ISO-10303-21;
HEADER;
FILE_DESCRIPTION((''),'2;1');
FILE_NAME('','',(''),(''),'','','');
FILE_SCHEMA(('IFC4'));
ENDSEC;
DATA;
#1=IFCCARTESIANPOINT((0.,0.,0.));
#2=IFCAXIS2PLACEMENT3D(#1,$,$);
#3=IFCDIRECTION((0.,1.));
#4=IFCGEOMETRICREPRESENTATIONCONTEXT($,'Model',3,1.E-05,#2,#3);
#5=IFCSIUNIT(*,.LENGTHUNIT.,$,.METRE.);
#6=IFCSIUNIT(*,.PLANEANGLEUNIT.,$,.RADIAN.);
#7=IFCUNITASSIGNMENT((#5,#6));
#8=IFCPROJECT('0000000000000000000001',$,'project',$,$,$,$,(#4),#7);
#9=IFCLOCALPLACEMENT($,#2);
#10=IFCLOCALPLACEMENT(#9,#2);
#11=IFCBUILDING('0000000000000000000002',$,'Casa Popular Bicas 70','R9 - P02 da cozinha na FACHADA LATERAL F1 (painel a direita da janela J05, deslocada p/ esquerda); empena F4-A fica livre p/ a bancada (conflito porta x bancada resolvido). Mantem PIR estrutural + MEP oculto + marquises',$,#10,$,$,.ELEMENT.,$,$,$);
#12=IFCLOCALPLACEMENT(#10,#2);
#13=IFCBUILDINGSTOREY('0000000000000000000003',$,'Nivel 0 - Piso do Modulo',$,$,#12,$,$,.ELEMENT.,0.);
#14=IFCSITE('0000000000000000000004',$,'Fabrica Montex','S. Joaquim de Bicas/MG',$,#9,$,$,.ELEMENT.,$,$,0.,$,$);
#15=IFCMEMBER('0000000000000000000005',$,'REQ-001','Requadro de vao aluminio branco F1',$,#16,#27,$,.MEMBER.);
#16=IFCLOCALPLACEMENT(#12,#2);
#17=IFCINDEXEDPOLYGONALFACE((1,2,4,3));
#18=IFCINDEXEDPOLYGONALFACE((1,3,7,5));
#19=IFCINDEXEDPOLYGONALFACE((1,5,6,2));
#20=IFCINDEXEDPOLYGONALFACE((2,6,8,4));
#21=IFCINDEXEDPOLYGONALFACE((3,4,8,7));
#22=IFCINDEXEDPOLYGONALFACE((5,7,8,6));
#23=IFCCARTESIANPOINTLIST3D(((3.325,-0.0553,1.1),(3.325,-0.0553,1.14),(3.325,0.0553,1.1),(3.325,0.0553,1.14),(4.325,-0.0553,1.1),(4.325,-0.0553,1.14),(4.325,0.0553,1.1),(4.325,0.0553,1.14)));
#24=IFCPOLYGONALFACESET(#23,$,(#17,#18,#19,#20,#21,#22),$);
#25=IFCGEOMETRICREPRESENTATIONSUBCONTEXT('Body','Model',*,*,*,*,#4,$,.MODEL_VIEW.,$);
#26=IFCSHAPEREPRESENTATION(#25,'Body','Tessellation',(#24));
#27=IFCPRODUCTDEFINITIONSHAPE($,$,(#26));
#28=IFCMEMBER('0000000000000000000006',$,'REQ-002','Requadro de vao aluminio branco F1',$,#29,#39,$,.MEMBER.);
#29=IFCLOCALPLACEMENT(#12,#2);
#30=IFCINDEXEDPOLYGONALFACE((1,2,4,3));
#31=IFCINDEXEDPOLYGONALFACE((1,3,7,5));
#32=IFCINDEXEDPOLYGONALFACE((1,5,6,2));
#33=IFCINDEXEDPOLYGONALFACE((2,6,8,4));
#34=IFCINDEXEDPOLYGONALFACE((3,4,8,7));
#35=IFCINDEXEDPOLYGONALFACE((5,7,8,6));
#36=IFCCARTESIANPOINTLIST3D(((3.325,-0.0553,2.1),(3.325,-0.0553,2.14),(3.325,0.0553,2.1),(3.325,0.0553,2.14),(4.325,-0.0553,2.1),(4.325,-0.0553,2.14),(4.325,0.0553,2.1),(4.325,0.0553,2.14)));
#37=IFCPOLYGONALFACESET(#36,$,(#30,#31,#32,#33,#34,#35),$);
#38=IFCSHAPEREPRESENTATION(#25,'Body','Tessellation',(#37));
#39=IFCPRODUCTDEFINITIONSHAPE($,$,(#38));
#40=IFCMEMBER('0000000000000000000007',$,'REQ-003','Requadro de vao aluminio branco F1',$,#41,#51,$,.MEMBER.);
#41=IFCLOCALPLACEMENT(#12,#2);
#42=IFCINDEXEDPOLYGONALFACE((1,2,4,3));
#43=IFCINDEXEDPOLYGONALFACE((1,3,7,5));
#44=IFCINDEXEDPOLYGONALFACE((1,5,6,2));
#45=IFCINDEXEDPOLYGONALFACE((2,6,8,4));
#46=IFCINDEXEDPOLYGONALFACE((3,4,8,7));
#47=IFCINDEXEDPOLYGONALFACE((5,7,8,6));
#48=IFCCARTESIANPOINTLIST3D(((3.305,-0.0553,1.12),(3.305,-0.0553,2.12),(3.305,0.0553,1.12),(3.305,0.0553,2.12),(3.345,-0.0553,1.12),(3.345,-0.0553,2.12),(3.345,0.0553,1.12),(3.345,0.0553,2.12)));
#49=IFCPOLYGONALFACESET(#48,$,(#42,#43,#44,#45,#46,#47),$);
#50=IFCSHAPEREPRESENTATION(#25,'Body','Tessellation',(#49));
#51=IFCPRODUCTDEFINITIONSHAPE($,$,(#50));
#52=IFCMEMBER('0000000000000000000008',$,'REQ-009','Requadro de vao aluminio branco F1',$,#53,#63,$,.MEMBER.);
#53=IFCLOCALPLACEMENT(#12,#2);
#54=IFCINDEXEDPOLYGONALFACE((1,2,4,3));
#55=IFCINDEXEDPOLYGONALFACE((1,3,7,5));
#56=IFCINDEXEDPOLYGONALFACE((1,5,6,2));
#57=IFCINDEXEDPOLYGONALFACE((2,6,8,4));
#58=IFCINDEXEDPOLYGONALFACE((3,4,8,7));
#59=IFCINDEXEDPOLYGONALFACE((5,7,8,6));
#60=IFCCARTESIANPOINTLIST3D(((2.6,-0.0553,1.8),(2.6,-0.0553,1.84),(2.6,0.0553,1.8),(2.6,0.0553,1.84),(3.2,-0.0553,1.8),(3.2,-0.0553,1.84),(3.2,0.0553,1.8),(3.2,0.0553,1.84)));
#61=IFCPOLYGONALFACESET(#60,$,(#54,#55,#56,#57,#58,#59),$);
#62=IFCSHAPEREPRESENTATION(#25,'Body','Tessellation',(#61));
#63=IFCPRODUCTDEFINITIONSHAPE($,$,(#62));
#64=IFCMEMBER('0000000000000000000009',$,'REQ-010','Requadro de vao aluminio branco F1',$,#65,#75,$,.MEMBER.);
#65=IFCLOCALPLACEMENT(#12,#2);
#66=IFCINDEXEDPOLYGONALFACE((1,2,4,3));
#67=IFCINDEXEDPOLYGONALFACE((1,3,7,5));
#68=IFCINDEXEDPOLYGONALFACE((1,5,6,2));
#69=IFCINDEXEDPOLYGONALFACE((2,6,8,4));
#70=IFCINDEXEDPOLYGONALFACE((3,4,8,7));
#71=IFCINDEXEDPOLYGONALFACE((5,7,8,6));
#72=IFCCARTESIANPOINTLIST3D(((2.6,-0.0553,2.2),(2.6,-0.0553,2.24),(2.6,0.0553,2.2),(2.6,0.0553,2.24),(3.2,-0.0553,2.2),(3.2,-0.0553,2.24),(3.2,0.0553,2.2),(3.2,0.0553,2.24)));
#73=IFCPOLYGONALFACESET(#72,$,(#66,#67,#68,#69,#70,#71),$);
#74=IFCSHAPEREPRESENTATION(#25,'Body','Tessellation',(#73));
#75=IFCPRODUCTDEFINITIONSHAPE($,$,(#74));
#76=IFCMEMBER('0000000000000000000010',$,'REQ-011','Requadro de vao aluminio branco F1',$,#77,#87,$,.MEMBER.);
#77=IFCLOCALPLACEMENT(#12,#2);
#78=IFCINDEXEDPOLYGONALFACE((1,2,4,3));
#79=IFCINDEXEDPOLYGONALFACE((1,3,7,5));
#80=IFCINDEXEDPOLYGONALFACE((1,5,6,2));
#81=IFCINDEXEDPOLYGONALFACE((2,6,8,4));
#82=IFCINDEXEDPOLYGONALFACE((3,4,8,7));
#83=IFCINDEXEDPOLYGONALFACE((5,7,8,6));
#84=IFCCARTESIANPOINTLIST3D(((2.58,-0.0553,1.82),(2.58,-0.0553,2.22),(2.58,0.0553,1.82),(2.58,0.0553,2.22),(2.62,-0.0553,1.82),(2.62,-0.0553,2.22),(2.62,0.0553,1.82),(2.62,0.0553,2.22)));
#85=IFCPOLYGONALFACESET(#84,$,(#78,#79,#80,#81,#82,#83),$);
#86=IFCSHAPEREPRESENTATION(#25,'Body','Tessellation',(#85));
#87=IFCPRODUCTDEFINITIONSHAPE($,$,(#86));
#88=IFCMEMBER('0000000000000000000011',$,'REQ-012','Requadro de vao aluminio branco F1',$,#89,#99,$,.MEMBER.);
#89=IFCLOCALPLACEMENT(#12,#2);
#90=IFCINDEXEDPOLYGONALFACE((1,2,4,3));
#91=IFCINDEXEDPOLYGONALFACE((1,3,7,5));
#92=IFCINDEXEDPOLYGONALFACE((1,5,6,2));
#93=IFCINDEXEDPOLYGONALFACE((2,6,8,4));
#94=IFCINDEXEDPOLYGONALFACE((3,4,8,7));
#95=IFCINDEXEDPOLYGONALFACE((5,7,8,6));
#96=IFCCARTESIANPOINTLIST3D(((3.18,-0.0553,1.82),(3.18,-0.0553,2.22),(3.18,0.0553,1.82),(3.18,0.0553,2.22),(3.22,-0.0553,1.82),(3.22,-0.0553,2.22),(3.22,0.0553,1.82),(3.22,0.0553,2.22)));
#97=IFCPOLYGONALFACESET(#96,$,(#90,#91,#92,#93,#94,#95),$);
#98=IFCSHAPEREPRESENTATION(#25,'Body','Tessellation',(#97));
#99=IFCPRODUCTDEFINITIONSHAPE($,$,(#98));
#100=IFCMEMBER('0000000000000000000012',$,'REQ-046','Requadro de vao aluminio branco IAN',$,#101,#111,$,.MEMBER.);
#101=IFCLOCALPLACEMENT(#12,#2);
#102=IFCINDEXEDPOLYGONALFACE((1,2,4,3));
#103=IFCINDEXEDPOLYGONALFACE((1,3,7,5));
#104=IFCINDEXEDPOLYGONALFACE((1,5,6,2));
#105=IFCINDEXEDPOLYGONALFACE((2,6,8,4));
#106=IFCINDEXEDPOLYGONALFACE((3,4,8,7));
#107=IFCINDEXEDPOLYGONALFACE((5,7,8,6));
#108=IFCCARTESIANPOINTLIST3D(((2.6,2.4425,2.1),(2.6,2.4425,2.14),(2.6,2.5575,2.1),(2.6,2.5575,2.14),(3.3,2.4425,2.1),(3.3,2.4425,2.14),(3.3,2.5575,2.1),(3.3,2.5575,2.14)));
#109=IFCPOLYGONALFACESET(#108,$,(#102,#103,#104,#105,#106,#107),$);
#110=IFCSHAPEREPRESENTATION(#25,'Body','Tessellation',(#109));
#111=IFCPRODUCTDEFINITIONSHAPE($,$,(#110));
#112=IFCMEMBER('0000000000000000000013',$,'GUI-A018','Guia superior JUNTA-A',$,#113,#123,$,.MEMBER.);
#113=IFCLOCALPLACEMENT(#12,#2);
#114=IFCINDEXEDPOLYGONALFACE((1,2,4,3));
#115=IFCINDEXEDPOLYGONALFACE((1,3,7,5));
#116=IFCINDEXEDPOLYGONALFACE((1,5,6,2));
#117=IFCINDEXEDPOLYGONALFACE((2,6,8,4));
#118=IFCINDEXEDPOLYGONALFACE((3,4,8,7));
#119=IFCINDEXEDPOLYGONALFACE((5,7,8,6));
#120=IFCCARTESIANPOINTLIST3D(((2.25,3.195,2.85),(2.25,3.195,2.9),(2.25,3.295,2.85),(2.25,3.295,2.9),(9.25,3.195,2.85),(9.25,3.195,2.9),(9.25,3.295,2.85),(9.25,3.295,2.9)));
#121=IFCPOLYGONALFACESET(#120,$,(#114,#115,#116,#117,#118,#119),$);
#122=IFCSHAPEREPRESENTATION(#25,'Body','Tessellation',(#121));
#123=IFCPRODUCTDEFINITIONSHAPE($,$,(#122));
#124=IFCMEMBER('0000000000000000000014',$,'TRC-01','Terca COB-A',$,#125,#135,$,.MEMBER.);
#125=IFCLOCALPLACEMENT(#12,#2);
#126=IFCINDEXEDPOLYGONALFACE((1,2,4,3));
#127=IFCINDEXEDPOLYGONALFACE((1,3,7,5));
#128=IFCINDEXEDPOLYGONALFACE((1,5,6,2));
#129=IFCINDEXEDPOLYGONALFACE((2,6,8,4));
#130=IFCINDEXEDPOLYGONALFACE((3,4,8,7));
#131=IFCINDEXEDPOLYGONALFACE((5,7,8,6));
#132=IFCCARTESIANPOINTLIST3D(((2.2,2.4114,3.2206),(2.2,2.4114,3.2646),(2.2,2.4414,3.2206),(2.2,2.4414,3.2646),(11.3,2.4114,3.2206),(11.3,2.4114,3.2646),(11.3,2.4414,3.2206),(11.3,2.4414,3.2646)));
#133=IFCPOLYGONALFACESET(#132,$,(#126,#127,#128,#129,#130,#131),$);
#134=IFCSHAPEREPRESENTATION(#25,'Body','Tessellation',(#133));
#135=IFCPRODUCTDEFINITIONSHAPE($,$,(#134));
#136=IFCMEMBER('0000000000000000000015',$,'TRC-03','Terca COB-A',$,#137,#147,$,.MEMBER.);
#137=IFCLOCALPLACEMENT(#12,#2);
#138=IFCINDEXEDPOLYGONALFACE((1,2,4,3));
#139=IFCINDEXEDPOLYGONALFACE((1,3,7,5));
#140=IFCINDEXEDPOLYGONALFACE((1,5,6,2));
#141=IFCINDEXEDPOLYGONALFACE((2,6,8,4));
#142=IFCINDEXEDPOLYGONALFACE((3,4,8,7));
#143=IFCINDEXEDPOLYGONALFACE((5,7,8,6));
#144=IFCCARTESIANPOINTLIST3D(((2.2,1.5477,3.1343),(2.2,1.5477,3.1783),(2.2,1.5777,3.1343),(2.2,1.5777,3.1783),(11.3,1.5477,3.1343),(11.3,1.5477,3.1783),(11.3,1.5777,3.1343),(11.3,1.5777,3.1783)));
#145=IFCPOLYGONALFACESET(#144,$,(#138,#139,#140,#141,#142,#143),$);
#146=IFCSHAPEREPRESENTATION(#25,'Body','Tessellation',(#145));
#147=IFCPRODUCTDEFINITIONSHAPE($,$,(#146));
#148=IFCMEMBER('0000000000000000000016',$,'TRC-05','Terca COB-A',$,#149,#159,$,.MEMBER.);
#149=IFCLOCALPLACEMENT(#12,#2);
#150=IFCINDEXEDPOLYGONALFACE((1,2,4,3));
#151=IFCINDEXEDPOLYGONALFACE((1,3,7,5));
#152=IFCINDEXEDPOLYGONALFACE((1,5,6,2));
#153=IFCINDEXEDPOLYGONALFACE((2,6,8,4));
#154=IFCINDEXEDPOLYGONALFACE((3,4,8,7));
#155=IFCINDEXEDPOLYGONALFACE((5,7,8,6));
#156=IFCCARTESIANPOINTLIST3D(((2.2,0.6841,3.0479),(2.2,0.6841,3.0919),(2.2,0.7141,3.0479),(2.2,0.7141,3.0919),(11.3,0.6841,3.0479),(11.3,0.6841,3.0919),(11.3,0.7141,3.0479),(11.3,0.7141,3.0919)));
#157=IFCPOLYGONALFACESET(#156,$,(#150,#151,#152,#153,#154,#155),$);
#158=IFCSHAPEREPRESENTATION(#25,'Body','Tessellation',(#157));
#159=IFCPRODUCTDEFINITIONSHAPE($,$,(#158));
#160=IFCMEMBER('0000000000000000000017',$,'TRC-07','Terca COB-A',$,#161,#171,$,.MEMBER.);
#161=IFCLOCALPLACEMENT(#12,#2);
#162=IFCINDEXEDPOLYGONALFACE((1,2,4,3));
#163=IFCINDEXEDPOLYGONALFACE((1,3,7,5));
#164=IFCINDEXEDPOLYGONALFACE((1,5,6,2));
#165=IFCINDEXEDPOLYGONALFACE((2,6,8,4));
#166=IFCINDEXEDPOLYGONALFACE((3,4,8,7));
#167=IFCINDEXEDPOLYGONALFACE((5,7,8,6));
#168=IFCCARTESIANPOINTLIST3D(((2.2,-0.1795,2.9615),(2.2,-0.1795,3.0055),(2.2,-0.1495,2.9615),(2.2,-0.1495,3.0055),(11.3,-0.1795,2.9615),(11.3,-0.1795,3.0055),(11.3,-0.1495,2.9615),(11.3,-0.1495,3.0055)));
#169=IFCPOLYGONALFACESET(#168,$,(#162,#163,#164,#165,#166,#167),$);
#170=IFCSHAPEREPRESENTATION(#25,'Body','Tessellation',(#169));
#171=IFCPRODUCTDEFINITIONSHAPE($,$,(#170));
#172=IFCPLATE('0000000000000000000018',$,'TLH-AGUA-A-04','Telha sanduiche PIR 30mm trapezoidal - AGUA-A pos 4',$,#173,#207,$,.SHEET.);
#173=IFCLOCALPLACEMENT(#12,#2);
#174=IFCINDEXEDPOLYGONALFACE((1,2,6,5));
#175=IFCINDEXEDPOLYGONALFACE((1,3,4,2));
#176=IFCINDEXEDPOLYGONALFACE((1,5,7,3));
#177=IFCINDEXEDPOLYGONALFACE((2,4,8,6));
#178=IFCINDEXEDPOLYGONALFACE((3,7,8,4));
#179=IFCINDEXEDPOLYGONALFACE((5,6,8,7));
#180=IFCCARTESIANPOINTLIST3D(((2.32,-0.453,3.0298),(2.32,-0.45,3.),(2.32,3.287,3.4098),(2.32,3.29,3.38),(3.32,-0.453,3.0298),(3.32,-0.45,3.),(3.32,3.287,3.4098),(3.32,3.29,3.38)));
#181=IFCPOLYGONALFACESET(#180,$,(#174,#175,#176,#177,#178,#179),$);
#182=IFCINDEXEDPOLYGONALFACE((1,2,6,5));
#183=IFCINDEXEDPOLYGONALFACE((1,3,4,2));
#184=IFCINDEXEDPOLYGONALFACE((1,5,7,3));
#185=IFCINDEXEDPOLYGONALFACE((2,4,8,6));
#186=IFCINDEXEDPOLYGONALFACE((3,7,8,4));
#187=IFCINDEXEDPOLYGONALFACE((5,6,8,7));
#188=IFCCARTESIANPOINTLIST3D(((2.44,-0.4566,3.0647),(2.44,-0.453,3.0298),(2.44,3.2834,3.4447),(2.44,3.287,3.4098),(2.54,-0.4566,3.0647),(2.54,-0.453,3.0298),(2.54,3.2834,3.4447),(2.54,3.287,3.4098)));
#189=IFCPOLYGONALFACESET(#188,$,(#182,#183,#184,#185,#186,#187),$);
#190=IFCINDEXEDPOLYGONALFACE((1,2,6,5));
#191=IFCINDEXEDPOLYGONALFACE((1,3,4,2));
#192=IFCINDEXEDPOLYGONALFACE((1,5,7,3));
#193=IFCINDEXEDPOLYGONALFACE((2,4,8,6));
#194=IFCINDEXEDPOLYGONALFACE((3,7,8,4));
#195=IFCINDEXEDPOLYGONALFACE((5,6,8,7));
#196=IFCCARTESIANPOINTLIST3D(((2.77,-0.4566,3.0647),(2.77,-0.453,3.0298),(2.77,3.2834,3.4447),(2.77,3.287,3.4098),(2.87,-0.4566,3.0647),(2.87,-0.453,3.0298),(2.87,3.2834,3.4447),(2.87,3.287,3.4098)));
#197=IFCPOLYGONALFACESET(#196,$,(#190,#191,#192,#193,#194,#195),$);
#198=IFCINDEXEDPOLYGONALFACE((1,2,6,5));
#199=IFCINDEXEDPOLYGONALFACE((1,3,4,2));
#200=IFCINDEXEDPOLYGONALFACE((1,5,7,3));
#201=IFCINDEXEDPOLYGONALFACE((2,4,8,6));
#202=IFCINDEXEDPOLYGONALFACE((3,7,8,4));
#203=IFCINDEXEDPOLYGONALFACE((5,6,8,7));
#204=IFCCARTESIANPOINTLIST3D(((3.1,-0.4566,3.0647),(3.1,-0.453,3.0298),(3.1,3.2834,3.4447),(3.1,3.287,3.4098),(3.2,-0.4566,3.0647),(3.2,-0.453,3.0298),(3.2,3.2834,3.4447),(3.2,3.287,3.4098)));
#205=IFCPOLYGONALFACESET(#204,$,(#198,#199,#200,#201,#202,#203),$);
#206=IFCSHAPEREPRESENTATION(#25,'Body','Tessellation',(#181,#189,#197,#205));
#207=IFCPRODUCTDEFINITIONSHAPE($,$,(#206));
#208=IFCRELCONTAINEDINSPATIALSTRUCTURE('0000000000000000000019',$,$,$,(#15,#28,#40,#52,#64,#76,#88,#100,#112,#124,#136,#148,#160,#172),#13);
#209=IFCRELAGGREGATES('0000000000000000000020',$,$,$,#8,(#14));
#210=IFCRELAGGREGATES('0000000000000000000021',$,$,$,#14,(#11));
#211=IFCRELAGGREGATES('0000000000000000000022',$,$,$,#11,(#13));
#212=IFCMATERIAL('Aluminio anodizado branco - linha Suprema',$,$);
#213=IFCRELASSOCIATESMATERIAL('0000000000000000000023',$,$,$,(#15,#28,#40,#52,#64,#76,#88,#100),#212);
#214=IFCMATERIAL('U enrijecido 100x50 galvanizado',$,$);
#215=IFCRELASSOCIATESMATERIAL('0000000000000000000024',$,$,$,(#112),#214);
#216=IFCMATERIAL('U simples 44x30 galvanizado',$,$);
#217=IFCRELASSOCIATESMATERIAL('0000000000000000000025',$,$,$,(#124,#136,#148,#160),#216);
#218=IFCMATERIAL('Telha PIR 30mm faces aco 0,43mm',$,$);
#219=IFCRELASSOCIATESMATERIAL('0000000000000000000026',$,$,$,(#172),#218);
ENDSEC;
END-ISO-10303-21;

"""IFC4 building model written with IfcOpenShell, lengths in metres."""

from ifc_helpers import new_model, si_unit, direction, frame, frame_2d, origin, origin_2d, place, context, subcontext, project, spatial, rectangle, extrude, material, element, save


model = new_model("IFC4")

# Units and contexts
model_context = context("Model", 3, precision=1e-05, world=origin(), true_north=direction((0.0, 1.0)))
body_context = subcontext(model_context, "Body", "Model", "MODEL_VIEW")
ifc_project = project(units=[si_unit("LENGTHUNIT", "METRE"), si_unit("PLANEANGLEUNIT", "RADIAN")], contexts=[model_context])

# Site, building, storey
site_placement = place(None, origin())
site = spatial("IfcSite", under=ifc_project, at=site_placement, Name="Fabrica Montex", Description="S. Joaquim de Bicas/MG", CompositionType="ELEMENT", RefElevation=0.0)
building_placement = place(site_placement, origin())
building = spatial("IfcBuilding", under=site, at=building_placement, Name="Casa Popular Bicas 70", Description="R9 - P02 da cozinha na FACHADA LATERAL F1 (painel a direita da janela J05, deslocada p/ esquerda); empena F4-A fica livre p/ a bancada (conflito porta x bancada resolvido). Mantem PIR estrutural + MEP oculto + marquises", CompositionType="ELEMENT")
storey_placement = place(building_placement, origin())
storey = spatial("IfcBuildingStorey", under=building, at=storey_placement, Name="Nivel 0 - Piso do Modulo", CompositionType="ELEMENT", Elevation=0.0)

# Members
ifc_material_1 = material(Name="Aluminio anodizado branco - linha Suprema")
for number, where, z_axis, x_axis, name in (
    (1, (3.325, 0.0, 1.12), (1.0, 0.0, 0.0), (0.0, 0.0, 1.0), "REQ-001"),
    (2, (3.325, 0.0, 2.12), (1.0, 0.0, 0.0), (0.0, 0.0, 1.0), "REQ-002"),
    (3, (3.325, 0.0, 1.12), (0.0, 0.0, 1.0), (1.0, 0.0, 0.0), "REQ-003"),
):
    element("IfcMember", number, at=place(storey_placement, frame(where, z_axis=z_axis, x_axis=x_axis)), inside=storey, material=ifc_material_1, Name=name, Description="Requadro de vao aluminio branco F1", PredefinedType="MEMBER", context=body_context, shape_type="SweptSolid", body=[
        extrude(rectangle(XDim=0.04, YDim=0.1105, at=origin_2d()), origin(), (0.0, 0.0, 1.0), 1.0),
    ])
for number, where, z_axis, x_axis, name in (
    (4, (2.6, 0.0, 1.82), (1.0, 0.0, 0.0), (0.0, 0.0, 1.0), "REQ-009"),
    (5, (2.6, 0.0, 2.22), (1.0, 0.0, 0.0), (0.0, 0.0, 1.0), "REQ-010"),
):
    element("IfcMember", number, at=place(storey_placement, frame(where, z_axis=z_axis, x_axis=x_axis)), inside=storey, material=ifc_material_1, Name=name, Description="Requadro de vao aluminio branco F1", PredefinedType="MEMBER", context=body_context, shape_type="SweptSolid", body=[
        extrude(rectangle(XDim=0.04, YDim=0.1105, at=origin_2d()), origin(), (0.0, 0.0, 1.0), 0.6),
    ])
for number, where, z_axis, x_axis, name in (
    (6, (2.6, 0.0, 1.82), (0.0, 0.0, 1.0), (1.0, 0.0, 0.0), "REQ-011"),
    (7, (3.2, 0.0, 1.82), (0.0, 0.0, 1.0), (1.0, 0.0, 0.0), "REQ-012"),
):
    element("IfcMember", number, at=place(storey_placement, frame(where, z_axis=z_axis, x_axis=x_axis)), inside=storey, material=ifc_material_1, Name=name, Description="Requadro de vao aluminio branco F1", PredefinedType="MEMBER", context=body_context, shape_type="SweptSolid", body=[
        extrude(rectangle(XDim=0.04, YDim=0.1105, at=origin_2d()), origin(), (0.0, 0.0, 1.0), 0.4),
    ])
member_1_placement = place(storey_placement, frame((2.6, 2.5, 2.12), z_axis=(1.0, 0.0, 0.0), x_axis=(0.0, 0.0, 1.0)))
element("IfcMember", 8, at=member_1_placement, inside=storey, material=ifc_material_1, Name="REQ-046", Description="Requadro de vao aluminio branco IAN", PredefinedType="MEMBER", context=body_context, shape_type="SweptSolid", body=[
    extrude(rectangle(XDim=0.04, YDim=0.115, at=origin_2d()), origin(), (0.0, 0.0, 1.0), 0.7),
])
ifc_material_2 = material(Name="U enrijecido 100x50 galvanizado")
member_2_placement = place(storey_placement, frame((2.25, 3.245, 2.875), z_axis=(1.0, 0.0, 0.0), x_axis=(0.0, 0.0, 1.0)))
element("IfcMember", 9, at=member_2_placement, inside=storey, material=ifc_material_2, Name="GUI-A018", Description="Guia superior JUNTA-A", PredefinedType="MEMBER", context=body_context, shape_type="SweptSolid", body=[
    extrude(rectangle(XDim=0.05, YDim=0.1, at=origin_2d()), origin(), (0.0, 0.0, 1.0), 7.0),
])
ifc_material_3 = material(Name="U simples 44x30 galvanizado")
for number, where, z_axis, x_axis, name in (
    (10, (2.2, 2.4264, 3.2426), (1.0, 0.0, 0.0), (0.0, 0.0, 1.0), "TRC-01"),
    (11, (2.2, 1.5627, 3.1563), (1.0, 0.0, 0.0), (0.0, 0.0, 1.0), "TRC-03"),
    (12, (2.2, 0.6991, 3.0699), (1.0, 0.0, 0.0), (0.0, 0.0, 1.0), "TRC-05"),
    (13, (2.2, -0.1645, 2.9835), (1.0, 0.0, 0.0), (0.0, 0.0, 1.0), "TRC-07"),
):
    element("IfcMember", number, at=place(storey_placement, frame(where, z_axis=z_axis, x_axis=x_axis)), inside=storey, material=ifc_material_3, Name=name, Description="Terca COB-A", PredefinedType="MEMBER", context=body_context, shape_type="SweptSolid", body=[
        extrude(rectangle(XDim=0.044, YDim=0.03, at=origin_2d()), origin(), (0.0, 0.0, 1.0), 9.1),
    ])

# Plate
ifc_material_4 = material(Name="Telha PIR 30mm faces aco 0,43mm")
for number, where, z_axis, x_axis, name in (
    (14, (2.32, -0.45, 3.0), (0.0, -0.101084, 0.994878), (1.0, 0.0, 0.0), "TLH-AGUA-A-04"),
):
    element("IfcPlate", number, at=place(storey_placement, frame(where, z_axis=z_axis, x_axis=x_axis)), inside=storey, material=ifc_material_4, Name=name, Description="Telha sanduiche PIR 30mm trapezoidal - AGUA-A pos 4", PredefinedType="SHEET", context=body_context, shape_type="SweptSolid", body=[
        extrude(rectangle(XDim=1.0, YDim=3.7593, at=frame_2d((0.5, 1.8796))), origin(), (0.0, 0.0, 1.0), 0.03),
        extrude(rectangle(XDim=0.1, YDim=3.7593, at=frame_2d((0.17, 1.8796))), frame((0.0, 0.0, 0.03)), (0.0, 0.0, 1.0), 0.035),
        extrude(rectangle(XDim=0.1, YDim=3.7593, at=frame_2d((0.5, 1.8796))), frame((0.0, 0.0, 0.03)), (0.0, 0.0, 1.0), 0.035),
        extrude(rectangle(XDim=0.1, YDim=3.7593, at=frame_2d((0.83, 1.8796))), frame((0.0, 0.0, 0.03)), (0.0, 0.0, 1.0), 0.035),
    ])

save(model, "model.ifc")
